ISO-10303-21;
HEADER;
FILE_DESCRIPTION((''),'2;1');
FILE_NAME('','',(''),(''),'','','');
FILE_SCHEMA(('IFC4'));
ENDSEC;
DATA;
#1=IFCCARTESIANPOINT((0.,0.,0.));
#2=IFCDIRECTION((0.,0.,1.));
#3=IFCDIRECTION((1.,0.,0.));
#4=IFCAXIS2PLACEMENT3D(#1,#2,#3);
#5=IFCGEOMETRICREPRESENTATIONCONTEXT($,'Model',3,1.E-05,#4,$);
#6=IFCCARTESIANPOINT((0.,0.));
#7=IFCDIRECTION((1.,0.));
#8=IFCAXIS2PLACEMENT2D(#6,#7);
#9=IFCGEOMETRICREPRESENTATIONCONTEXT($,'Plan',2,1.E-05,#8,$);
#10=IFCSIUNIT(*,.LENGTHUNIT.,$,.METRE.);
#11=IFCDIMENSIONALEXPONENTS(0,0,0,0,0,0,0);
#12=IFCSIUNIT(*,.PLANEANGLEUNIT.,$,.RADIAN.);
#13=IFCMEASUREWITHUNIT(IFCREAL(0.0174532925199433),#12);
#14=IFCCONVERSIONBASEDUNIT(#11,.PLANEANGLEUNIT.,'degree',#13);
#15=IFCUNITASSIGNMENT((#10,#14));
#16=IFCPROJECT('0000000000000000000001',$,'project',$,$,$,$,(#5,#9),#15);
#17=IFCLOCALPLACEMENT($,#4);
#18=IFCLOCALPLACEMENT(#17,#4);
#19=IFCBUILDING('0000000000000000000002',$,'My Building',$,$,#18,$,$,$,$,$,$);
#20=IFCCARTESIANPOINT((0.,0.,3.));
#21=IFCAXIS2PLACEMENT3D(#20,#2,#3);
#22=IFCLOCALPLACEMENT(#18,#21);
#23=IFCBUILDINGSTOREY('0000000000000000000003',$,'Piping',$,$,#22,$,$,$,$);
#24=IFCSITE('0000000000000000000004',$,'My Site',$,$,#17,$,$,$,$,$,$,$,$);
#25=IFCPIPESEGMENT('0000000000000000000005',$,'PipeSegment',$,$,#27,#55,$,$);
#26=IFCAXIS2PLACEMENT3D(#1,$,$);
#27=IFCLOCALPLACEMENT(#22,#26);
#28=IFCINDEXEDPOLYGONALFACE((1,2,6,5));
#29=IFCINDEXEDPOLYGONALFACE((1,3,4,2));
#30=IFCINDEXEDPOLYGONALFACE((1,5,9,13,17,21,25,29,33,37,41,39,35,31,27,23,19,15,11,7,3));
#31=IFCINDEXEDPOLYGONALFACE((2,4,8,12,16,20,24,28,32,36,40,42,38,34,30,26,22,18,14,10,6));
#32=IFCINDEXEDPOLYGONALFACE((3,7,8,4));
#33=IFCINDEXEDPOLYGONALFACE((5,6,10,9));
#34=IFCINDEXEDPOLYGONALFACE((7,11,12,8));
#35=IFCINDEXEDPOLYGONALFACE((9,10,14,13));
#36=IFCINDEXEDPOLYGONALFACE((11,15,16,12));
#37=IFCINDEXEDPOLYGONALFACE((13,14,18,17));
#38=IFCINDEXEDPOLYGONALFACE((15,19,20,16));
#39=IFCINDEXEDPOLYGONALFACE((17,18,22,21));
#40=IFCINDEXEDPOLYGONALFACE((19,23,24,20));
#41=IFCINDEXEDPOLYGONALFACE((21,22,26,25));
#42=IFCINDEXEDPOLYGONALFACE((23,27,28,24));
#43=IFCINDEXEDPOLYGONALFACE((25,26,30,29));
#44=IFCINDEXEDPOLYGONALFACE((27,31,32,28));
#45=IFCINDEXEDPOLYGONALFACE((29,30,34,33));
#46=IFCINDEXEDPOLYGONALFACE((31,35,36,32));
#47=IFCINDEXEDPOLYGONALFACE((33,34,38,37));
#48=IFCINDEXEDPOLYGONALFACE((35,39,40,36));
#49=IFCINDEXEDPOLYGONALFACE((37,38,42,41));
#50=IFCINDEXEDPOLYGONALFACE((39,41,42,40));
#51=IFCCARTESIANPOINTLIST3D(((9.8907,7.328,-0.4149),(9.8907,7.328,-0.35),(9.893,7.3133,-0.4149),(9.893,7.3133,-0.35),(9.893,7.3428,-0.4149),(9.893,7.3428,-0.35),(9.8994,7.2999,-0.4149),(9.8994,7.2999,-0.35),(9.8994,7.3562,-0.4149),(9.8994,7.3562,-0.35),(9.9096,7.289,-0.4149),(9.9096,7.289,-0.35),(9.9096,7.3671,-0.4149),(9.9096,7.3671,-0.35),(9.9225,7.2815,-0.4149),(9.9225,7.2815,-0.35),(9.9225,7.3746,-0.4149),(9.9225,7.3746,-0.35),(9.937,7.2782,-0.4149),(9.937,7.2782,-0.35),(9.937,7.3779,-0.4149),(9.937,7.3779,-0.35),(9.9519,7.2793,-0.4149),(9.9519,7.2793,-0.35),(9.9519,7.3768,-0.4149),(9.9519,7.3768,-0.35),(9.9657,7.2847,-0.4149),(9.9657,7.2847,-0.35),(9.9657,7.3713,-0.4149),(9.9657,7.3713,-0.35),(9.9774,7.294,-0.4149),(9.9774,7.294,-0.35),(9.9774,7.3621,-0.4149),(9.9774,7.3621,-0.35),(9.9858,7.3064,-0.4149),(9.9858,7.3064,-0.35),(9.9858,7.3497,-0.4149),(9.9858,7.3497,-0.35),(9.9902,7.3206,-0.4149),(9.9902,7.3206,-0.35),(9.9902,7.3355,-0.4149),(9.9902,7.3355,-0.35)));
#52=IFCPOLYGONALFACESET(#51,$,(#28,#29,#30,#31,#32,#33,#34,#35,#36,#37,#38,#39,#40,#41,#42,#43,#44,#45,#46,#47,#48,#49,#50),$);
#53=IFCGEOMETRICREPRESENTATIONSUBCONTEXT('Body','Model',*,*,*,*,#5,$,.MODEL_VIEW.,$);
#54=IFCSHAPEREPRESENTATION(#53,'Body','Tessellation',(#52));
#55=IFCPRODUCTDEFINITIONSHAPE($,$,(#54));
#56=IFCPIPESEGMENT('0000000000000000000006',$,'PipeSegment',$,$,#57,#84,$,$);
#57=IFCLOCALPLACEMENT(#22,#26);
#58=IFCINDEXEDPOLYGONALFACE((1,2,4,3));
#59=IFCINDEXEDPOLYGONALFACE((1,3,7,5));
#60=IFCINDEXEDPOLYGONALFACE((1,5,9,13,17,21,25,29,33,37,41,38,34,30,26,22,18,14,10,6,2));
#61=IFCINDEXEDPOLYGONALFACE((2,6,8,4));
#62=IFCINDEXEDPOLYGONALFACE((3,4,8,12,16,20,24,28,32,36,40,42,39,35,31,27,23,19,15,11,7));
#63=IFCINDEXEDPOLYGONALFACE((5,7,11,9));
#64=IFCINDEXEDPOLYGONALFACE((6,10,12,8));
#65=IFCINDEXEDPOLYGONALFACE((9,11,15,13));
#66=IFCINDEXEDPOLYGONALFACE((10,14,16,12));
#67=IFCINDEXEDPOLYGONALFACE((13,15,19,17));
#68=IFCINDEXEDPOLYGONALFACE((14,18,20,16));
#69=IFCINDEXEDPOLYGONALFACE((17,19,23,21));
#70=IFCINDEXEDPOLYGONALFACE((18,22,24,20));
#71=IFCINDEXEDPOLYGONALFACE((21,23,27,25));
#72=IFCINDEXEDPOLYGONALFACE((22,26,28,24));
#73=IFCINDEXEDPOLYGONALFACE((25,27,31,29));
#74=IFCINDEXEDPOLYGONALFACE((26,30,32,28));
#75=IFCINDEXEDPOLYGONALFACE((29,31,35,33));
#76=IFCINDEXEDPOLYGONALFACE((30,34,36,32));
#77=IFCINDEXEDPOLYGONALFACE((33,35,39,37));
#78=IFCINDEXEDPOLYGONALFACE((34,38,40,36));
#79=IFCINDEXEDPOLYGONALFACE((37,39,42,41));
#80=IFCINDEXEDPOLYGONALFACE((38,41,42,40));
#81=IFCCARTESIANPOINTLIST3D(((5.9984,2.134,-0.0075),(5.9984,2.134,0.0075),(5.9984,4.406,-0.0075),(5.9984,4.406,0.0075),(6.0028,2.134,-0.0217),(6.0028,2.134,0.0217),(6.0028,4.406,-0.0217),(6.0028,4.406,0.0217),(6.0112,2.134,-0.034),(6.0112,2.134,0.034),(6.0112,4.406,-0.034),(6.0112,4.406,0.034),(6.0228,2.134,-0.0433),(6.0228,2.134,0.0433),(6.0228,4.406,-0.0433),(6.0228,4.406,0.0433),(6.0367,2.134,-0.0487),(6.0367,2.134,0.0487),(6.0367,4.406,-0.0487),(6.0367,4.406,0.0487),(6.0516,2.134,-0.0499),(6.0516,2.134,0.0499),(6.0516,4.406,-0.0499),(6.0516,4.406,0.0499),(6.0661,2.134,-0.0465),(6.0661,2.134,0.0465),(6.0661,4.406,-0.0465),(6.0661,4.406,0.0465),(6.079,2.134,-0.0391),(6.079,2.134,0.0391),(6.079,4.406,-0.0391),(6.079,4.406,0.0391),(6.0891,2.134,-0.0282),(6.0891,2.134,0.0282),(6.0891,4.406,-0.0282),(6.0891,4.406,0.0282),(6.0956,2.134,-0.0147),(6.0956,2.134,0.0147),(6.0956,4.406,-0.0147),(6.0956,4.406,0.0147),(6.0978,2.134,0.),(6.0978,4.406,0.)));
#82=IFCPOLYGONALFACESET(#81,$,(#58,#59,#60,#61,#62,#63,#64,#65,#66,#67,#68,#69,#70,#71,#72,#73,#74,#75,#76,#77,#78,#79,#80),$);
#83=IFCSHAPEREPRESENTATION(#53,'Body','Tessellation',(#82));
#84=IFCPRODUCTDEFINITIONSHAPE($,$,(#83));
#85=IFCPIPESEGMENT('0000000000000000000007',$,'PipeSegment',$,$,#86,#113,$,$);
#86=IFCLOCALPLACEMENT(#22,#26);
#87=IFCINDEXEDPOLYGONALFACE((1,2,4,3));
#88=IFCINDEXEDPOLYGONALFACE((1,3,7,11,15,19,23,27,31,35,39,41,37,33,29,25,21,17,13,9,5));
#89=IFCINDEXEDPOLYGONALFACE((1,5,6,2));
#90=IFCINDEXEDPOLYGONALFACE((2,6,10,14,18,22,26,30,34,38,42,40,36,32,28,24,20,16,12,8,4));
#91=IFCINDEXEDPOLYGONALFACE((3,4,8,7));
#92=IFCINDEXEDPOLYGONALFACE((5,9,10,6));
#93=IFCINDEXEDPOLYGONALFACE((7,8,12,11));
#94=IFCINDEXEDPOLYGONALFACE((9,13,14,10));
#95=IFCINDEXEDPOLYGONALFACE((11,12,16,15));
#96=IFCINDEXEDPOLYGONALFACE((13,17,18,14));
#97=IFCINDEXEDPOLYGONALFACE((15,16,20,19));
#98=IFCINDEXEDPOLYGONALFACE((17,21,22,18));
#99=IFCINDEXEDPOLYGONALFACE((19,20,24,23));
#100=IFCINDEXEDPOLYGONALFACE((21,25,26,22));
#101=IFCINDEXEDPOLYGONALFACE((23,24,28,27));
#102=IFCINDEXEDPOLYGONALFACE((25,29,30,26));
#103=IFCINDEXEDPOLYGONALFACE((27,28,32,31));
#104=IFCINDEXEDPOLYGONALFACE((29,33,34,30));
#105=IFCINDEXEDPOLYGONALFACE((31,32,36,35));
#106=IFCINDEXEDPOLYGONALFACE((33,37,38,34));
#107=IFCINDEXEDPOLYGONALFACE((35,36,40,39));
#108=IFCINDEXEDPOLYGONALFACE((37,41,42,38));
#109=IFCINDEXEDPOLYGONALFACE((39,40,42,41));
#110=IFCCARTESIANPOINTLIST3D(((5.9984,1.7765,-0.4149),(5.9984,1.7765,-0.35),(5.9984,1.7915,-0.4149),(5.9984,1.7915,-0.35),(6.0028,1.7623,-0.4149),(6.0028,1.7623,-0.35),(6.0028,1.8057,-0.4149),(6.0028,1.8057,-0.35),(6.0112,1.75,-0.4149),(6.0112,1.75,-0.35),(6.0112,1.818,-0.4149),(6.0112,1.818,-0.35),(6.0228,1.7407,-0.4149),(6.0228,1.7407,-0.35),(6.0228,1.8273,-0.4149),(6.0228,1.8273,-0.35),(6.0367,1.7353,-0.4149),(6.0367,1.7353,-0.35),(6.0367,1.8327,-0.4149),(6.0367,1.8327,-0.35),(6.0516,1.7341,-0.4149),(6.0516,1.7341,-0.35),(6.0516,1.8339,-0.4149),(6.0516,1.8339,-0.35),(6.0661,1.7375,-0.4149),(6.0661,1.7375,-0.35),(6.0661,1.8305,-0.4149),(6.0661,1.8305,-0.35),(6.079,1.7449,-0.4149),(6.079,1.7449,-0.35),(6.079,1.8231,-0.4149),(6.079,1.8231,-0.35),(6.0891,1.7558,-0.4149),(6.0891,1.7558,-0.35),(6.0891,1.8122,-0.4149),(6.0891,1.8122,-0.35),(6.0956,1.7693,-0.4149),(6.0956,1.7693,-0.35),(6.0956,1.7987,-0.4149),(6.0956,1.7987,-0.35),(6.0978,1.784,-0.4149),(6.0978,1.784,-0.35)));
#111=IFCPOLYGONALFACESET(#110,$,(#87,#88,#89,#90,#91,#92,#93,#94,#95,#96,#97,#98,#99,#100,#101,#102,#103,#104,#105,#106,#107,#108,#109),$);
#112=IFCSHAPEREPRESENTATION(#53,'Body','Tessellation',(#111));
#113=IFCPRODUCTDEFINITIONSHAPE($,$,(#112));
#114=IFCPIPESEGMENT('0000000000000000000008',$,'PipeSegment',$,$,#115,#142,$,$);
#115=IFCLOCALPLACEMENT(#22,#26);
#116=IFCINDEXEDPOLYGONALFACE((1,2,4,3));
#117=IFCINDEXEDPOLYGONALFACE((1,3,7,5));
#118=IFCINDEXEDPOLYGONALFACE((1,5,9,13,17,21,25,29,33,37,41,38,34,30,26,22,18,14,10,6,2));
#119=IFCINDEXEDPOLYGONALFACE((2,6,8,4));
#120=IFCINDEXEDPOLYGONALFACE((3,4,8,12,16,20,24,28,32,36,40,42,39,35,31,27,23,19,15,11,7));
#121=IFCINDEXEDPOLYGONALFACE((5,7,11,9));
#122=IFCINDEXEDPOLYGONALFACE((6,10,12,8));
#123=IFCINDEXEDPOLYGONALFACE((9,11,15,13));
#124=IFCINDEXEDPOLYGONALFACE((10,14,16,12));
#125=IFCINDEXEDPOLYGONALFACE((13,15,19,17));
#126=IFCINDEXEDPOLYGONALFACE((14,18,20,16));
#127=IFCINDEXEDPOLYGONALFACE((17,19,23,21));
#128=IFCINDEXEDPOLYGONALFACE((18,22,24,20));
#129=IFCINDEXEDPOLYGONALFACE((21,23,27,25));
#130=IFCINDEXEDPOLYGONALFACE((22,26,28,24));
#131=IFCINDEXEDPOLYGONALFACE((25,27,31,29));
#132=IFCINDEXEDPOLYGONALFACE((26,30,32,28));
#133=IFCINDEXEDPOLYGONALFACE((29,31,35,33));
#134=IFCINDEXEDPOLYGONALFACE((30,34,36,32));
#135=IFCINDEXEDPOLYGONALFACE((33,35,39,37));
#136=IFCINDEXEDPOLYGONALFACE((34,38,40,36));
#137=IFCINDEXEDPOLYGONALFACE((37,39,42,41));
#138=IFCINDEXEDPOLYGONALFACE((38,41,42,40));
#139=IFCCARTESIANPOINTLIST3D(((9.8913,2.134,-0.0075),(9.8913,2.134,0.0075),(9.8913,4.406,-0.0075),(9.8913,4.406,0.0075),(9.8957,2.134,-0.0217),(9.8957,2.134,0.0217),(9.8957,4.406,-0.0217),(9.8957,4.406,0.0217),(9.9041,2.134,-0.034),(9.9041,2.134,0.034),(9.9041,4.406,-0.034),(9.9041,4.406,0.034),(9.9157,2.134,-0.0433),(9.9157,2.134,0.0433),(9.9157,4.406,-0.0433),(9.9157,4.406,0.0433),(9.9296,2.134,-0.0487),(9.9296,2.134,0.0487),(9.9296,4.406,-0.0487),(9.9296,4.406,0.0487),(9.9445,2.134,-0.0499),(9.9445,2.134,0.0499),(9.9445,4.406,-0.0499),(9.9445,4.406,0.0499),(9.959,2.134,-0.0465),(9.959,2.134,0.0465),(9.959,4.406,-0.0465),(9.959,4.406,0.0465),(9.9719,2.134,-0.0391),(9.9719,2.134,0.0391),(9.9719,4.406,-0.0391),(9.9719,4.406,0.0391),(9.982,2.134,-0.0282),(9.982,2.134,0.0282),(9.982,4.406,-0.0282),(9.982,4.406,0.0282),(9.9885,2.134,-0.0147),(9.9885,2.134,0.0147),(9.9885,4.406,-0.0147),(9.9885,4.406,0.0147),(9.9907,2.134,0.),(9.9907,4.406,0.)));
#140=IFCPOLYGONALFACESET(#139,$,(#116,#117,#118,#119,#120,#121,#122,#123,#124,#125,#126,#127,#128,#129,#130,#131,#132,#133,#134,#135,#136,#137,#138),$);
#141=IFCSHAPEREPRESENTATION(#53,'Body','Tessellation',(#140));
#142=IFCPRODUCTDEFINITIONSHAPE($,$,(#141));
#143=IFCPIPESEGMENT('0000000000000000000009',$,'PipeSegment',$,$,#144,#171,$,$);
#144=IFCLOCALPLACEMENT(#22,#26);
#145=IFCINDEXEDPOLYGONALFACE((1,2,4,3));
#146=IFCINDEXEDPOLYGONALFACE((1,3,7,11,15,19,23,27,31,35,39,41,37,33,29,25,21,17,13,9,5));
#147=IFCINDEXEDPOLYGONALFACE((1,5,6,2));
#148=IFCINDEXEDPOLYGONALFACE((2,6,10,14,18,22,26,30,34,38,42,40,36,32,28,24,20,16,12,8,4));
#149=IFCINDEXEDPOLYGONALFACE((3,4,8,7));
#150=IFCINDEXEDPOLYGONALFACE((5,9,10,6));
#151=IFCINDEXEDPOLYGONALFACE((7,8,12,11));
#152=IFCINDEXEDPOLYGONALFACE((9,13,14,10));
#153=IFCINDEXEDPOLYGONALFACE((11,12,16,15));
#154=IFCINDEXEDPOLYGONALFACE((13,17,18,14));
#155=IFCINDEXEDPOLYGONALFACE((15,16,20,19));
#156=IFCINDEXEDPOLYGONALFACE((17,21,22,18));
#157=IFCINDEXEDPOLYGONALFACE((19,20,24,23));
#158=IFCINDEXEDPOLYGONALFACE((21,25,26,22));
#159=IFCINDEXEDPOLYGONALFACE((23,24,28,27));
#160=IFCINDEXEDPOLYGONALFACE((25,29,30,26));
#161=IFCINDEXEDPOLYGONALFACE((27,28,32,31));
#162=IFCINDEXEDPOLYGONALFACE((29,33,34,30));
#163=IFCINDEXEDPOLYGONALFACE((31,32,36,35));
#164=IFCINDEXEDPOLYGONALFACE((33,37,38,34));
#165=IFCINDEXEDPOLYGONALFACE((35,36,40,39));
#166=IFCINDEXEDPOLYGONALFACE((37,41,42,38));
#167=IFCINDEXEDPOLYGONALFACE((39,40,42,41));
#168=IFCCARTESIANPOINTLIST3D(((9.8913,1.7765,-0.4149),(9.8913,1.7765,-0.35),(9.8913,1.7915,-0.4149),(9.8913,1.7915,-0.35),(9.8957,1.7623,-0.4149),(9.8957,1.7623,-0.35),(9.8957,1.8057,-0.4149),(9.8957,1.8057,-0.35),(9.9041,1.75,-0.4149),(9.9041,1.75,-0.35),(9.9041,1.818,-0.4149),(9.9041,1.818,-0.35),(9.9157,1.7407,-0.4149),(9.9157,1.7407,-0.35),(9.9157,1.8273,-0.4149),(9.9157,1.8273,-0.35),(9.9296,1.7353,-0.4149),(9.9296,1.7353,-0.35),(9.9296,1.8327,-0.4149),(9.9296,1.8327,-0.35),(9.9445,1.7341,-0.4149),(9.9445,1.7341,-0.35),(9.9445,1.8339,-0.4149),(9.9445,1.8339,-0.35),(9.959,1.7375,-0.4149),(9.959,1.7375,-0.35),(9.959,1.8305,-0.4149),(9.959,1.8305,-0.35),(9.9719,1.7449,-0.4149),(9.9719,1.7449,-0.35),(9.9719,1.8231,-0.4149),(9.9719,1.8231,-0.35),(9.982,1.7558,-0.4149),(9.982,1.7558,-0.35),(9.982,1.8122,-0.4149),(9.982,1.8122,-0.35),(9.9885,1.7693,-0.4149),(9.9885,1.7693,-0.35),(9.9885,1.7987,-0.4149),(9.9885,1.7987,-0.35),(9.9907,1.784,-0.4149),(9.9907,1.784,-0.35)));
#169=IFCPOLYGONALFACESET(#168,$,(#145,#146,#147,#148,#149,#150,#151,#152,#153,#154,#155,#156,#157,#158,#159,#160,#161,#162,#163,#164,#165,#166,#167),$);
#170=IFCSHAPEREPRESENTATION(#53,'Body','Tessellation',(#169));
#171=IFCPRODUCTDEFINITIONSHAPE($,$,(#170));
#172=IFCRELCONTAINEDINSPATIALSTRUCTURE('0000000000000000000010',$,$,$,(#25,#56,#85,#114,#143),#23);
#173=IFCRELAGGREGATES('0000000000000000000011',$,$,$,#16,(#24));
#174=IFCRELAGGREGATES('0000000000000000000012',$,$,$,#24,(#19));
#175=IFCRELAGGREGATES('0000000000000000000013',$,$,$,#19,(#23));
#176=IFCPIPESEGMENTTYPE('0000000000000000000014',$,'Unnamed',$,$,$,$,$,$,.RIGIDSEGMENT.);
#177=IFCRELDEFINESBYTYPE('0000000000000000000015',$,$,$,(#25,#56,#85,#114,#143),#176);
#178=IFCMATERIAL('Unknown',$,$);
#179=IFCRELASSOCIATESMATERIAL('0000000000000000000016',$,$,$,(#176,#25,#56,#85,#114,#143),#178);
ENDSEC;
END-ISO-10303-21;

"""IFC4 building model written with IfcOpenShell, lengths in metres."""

from ifc_helpers import new_model, entity, si_unit, converted_unit, frame, origin_with_axes, origin_2d_with_axis, place, context, subcontext, project, spatial, circle, extrude, material, material_profile, profile_set, profile_usage, type_object, element, save


model = new_model("IFC4")

# Units and contexts
model_context = context("Model", 3, precision=1e-05, world=origin_with_axes())
plan_context = context("Plan", 2, precision=1e-05, world=origin_2d_with_axis())
body_context = subcontext(model_context, "Body", "Model", "MODEL_VIEW")
ifc_project = project(units=[si_unit("LENGTHUNIT", "METRE"), converted_unit("PLANEANGLEUNIT", "degree", entity("IfcReal", 0.0174532925199433), si_unit("PLANEANGLEUNIT", "RADIAN"), dimensions=[0, 0, 0, 0, 0, 0, 0])], contexts=[model_context, plan_context])

# Site, building, storey
site_placement = place(None, origin_with_axes())
site = spatial("IfcSite", under=ifc_project, at=site_placement, Name="My Site")
building_placement = place(site_placement, origin_with_axes())
building = spatial("IfcBuilding", under=site, at=building_placement, Name="My Building")
storey_placement = place(building_placement, frame((0.0, 0.0, 3.0), z_axis=(0.0, 0.0, 1.0), x_axis=(1.0, 0.0, 0.0)))
storey = spatial("IfcBuildingStorey", under=building, at=storey_placement, Name="Piping")

# Pipe segments
ifc_material = material(Name="Unknown")
ifc_material_profile_1 = material_profile(ifc_material, circle(Radius=0.05))
ifc_profile_set_1 = profile_set([ifc_material_profile_1])
pipe_segment_type = type_object("IfcPipeSegmentType", Name="Unnamed", PredefinedType="RIGIDSEGMENT", material=ifc_profile_set_1)
ifc_profile_usage_1 = profile_usage(ifc_profile_set_1, cardinal=5)
pipe_segment_1_placement = place(storey_placement, frame((9.9407, 7.328, -0.35), z_axis=(0.0, 0.0, -1.0), x_axis=(-1.0, 0.0, 0.0)))
element("IfcPipeSegment", 1, at=pipe_segment_1_placement, inside=storey, type_object=pipe_segment_type, material=ifc_profile_usage_1, Name="PipeSegment", context=body_context, shape_type="SweptSolid", body=[
    extrude(circle(Radius=0.05), origin_with_axes(), (0.0, 0.0, 1.0), 0.0649),
])
ifc_profile_usage_2 = profile_usage(ifc_profile_set_1, cardinal=5)
pipe_segment_2_placement = place(storey_placement, frame((6.0478, 4.406, 0.0), z_axis=(0.0, -1.0, 0.0), x_axis=(1.0, 0.0, 0.0)))
element("IfcPipeSegment", 2, at=pipe_segment_2_placement, inside=storey, type_object=pipe_segment_type, material=ifc_profile_usage_2, Name="PipeSegment", context=body_context, shape_type="SweptSolid", body=[
    extrude(circle(Radius=0.05), origin_with_axes(), (0.0, 0.0, 1.0), 2.272),
])
ifc_profile_usage_3 = profile_usage(ifc_profile_set_1, cardinal=5)
pipe_segment_3_placement = place(storey_placement, frame((6.0478, 1.784, -0.35), z_axis=(0.0, 0.0, -1.0), x_axis=(1.0, 0.0, 0.0)))
element("IfcPipeSegment", 3, at=pipe_segment_3_placement, inside=storey, type_object=pipe_segment_type, material=ifc_profile_usage_3, Name="PipeSegment", context=body_context, shape_type="SweptSolid", body=[
    extrude(circle(Radius=0.05), origin_with_axes(), (0.0, 0.0, 1.0), 0.0649),
])
ifc_profile_usage_4 = profile_usage(ifc_profile_set_1, cardinal=5)
pipe_segment_4_placement = place(storey_placement, frame((9.9407, 4.406, 0.0), z_axis=(0.0, -1.0, 0.0), x_axis=(1.0, 0.0, 0.0)))
element("IfcPipeSegment", 4, at=pipe_segment_4_placement, inside=storey, type_object=pipe_segment_type, material=ifc_profile_usage_4, Name="PipeSegment", context=body_context, shape_type="SweptSolid", body=[
    extrude(circle(Radius=0.05), origin_with_axes(), (0.0, 0.0, 1.0), 2.272),
])
ifc_profile_usage_5 = profile_usage(ifc_profile_set_1, cardinal=5)
pipe_segment_5_placement = place(storey_placement, frame((9.9407, 1.784, -0.35), z_axis=(0.0, 0.0, -1.0), x_axis=(1.0, 0.0, 0.0)))
element("IfcPipeSegment", 5, at=pipe_segment_5_placement, inside=storey, type_object=pipe_segment_type, material=ifc_profile_usage_5, Name="PipeSegment", context=body_context, shape_type="SweptSolid", body=[
    extrude(circle(Radius=0.05), origin_with_axes(), (0.0, 0.0, 1.0), 0.0649),
])

save(model, "model.ifc")
